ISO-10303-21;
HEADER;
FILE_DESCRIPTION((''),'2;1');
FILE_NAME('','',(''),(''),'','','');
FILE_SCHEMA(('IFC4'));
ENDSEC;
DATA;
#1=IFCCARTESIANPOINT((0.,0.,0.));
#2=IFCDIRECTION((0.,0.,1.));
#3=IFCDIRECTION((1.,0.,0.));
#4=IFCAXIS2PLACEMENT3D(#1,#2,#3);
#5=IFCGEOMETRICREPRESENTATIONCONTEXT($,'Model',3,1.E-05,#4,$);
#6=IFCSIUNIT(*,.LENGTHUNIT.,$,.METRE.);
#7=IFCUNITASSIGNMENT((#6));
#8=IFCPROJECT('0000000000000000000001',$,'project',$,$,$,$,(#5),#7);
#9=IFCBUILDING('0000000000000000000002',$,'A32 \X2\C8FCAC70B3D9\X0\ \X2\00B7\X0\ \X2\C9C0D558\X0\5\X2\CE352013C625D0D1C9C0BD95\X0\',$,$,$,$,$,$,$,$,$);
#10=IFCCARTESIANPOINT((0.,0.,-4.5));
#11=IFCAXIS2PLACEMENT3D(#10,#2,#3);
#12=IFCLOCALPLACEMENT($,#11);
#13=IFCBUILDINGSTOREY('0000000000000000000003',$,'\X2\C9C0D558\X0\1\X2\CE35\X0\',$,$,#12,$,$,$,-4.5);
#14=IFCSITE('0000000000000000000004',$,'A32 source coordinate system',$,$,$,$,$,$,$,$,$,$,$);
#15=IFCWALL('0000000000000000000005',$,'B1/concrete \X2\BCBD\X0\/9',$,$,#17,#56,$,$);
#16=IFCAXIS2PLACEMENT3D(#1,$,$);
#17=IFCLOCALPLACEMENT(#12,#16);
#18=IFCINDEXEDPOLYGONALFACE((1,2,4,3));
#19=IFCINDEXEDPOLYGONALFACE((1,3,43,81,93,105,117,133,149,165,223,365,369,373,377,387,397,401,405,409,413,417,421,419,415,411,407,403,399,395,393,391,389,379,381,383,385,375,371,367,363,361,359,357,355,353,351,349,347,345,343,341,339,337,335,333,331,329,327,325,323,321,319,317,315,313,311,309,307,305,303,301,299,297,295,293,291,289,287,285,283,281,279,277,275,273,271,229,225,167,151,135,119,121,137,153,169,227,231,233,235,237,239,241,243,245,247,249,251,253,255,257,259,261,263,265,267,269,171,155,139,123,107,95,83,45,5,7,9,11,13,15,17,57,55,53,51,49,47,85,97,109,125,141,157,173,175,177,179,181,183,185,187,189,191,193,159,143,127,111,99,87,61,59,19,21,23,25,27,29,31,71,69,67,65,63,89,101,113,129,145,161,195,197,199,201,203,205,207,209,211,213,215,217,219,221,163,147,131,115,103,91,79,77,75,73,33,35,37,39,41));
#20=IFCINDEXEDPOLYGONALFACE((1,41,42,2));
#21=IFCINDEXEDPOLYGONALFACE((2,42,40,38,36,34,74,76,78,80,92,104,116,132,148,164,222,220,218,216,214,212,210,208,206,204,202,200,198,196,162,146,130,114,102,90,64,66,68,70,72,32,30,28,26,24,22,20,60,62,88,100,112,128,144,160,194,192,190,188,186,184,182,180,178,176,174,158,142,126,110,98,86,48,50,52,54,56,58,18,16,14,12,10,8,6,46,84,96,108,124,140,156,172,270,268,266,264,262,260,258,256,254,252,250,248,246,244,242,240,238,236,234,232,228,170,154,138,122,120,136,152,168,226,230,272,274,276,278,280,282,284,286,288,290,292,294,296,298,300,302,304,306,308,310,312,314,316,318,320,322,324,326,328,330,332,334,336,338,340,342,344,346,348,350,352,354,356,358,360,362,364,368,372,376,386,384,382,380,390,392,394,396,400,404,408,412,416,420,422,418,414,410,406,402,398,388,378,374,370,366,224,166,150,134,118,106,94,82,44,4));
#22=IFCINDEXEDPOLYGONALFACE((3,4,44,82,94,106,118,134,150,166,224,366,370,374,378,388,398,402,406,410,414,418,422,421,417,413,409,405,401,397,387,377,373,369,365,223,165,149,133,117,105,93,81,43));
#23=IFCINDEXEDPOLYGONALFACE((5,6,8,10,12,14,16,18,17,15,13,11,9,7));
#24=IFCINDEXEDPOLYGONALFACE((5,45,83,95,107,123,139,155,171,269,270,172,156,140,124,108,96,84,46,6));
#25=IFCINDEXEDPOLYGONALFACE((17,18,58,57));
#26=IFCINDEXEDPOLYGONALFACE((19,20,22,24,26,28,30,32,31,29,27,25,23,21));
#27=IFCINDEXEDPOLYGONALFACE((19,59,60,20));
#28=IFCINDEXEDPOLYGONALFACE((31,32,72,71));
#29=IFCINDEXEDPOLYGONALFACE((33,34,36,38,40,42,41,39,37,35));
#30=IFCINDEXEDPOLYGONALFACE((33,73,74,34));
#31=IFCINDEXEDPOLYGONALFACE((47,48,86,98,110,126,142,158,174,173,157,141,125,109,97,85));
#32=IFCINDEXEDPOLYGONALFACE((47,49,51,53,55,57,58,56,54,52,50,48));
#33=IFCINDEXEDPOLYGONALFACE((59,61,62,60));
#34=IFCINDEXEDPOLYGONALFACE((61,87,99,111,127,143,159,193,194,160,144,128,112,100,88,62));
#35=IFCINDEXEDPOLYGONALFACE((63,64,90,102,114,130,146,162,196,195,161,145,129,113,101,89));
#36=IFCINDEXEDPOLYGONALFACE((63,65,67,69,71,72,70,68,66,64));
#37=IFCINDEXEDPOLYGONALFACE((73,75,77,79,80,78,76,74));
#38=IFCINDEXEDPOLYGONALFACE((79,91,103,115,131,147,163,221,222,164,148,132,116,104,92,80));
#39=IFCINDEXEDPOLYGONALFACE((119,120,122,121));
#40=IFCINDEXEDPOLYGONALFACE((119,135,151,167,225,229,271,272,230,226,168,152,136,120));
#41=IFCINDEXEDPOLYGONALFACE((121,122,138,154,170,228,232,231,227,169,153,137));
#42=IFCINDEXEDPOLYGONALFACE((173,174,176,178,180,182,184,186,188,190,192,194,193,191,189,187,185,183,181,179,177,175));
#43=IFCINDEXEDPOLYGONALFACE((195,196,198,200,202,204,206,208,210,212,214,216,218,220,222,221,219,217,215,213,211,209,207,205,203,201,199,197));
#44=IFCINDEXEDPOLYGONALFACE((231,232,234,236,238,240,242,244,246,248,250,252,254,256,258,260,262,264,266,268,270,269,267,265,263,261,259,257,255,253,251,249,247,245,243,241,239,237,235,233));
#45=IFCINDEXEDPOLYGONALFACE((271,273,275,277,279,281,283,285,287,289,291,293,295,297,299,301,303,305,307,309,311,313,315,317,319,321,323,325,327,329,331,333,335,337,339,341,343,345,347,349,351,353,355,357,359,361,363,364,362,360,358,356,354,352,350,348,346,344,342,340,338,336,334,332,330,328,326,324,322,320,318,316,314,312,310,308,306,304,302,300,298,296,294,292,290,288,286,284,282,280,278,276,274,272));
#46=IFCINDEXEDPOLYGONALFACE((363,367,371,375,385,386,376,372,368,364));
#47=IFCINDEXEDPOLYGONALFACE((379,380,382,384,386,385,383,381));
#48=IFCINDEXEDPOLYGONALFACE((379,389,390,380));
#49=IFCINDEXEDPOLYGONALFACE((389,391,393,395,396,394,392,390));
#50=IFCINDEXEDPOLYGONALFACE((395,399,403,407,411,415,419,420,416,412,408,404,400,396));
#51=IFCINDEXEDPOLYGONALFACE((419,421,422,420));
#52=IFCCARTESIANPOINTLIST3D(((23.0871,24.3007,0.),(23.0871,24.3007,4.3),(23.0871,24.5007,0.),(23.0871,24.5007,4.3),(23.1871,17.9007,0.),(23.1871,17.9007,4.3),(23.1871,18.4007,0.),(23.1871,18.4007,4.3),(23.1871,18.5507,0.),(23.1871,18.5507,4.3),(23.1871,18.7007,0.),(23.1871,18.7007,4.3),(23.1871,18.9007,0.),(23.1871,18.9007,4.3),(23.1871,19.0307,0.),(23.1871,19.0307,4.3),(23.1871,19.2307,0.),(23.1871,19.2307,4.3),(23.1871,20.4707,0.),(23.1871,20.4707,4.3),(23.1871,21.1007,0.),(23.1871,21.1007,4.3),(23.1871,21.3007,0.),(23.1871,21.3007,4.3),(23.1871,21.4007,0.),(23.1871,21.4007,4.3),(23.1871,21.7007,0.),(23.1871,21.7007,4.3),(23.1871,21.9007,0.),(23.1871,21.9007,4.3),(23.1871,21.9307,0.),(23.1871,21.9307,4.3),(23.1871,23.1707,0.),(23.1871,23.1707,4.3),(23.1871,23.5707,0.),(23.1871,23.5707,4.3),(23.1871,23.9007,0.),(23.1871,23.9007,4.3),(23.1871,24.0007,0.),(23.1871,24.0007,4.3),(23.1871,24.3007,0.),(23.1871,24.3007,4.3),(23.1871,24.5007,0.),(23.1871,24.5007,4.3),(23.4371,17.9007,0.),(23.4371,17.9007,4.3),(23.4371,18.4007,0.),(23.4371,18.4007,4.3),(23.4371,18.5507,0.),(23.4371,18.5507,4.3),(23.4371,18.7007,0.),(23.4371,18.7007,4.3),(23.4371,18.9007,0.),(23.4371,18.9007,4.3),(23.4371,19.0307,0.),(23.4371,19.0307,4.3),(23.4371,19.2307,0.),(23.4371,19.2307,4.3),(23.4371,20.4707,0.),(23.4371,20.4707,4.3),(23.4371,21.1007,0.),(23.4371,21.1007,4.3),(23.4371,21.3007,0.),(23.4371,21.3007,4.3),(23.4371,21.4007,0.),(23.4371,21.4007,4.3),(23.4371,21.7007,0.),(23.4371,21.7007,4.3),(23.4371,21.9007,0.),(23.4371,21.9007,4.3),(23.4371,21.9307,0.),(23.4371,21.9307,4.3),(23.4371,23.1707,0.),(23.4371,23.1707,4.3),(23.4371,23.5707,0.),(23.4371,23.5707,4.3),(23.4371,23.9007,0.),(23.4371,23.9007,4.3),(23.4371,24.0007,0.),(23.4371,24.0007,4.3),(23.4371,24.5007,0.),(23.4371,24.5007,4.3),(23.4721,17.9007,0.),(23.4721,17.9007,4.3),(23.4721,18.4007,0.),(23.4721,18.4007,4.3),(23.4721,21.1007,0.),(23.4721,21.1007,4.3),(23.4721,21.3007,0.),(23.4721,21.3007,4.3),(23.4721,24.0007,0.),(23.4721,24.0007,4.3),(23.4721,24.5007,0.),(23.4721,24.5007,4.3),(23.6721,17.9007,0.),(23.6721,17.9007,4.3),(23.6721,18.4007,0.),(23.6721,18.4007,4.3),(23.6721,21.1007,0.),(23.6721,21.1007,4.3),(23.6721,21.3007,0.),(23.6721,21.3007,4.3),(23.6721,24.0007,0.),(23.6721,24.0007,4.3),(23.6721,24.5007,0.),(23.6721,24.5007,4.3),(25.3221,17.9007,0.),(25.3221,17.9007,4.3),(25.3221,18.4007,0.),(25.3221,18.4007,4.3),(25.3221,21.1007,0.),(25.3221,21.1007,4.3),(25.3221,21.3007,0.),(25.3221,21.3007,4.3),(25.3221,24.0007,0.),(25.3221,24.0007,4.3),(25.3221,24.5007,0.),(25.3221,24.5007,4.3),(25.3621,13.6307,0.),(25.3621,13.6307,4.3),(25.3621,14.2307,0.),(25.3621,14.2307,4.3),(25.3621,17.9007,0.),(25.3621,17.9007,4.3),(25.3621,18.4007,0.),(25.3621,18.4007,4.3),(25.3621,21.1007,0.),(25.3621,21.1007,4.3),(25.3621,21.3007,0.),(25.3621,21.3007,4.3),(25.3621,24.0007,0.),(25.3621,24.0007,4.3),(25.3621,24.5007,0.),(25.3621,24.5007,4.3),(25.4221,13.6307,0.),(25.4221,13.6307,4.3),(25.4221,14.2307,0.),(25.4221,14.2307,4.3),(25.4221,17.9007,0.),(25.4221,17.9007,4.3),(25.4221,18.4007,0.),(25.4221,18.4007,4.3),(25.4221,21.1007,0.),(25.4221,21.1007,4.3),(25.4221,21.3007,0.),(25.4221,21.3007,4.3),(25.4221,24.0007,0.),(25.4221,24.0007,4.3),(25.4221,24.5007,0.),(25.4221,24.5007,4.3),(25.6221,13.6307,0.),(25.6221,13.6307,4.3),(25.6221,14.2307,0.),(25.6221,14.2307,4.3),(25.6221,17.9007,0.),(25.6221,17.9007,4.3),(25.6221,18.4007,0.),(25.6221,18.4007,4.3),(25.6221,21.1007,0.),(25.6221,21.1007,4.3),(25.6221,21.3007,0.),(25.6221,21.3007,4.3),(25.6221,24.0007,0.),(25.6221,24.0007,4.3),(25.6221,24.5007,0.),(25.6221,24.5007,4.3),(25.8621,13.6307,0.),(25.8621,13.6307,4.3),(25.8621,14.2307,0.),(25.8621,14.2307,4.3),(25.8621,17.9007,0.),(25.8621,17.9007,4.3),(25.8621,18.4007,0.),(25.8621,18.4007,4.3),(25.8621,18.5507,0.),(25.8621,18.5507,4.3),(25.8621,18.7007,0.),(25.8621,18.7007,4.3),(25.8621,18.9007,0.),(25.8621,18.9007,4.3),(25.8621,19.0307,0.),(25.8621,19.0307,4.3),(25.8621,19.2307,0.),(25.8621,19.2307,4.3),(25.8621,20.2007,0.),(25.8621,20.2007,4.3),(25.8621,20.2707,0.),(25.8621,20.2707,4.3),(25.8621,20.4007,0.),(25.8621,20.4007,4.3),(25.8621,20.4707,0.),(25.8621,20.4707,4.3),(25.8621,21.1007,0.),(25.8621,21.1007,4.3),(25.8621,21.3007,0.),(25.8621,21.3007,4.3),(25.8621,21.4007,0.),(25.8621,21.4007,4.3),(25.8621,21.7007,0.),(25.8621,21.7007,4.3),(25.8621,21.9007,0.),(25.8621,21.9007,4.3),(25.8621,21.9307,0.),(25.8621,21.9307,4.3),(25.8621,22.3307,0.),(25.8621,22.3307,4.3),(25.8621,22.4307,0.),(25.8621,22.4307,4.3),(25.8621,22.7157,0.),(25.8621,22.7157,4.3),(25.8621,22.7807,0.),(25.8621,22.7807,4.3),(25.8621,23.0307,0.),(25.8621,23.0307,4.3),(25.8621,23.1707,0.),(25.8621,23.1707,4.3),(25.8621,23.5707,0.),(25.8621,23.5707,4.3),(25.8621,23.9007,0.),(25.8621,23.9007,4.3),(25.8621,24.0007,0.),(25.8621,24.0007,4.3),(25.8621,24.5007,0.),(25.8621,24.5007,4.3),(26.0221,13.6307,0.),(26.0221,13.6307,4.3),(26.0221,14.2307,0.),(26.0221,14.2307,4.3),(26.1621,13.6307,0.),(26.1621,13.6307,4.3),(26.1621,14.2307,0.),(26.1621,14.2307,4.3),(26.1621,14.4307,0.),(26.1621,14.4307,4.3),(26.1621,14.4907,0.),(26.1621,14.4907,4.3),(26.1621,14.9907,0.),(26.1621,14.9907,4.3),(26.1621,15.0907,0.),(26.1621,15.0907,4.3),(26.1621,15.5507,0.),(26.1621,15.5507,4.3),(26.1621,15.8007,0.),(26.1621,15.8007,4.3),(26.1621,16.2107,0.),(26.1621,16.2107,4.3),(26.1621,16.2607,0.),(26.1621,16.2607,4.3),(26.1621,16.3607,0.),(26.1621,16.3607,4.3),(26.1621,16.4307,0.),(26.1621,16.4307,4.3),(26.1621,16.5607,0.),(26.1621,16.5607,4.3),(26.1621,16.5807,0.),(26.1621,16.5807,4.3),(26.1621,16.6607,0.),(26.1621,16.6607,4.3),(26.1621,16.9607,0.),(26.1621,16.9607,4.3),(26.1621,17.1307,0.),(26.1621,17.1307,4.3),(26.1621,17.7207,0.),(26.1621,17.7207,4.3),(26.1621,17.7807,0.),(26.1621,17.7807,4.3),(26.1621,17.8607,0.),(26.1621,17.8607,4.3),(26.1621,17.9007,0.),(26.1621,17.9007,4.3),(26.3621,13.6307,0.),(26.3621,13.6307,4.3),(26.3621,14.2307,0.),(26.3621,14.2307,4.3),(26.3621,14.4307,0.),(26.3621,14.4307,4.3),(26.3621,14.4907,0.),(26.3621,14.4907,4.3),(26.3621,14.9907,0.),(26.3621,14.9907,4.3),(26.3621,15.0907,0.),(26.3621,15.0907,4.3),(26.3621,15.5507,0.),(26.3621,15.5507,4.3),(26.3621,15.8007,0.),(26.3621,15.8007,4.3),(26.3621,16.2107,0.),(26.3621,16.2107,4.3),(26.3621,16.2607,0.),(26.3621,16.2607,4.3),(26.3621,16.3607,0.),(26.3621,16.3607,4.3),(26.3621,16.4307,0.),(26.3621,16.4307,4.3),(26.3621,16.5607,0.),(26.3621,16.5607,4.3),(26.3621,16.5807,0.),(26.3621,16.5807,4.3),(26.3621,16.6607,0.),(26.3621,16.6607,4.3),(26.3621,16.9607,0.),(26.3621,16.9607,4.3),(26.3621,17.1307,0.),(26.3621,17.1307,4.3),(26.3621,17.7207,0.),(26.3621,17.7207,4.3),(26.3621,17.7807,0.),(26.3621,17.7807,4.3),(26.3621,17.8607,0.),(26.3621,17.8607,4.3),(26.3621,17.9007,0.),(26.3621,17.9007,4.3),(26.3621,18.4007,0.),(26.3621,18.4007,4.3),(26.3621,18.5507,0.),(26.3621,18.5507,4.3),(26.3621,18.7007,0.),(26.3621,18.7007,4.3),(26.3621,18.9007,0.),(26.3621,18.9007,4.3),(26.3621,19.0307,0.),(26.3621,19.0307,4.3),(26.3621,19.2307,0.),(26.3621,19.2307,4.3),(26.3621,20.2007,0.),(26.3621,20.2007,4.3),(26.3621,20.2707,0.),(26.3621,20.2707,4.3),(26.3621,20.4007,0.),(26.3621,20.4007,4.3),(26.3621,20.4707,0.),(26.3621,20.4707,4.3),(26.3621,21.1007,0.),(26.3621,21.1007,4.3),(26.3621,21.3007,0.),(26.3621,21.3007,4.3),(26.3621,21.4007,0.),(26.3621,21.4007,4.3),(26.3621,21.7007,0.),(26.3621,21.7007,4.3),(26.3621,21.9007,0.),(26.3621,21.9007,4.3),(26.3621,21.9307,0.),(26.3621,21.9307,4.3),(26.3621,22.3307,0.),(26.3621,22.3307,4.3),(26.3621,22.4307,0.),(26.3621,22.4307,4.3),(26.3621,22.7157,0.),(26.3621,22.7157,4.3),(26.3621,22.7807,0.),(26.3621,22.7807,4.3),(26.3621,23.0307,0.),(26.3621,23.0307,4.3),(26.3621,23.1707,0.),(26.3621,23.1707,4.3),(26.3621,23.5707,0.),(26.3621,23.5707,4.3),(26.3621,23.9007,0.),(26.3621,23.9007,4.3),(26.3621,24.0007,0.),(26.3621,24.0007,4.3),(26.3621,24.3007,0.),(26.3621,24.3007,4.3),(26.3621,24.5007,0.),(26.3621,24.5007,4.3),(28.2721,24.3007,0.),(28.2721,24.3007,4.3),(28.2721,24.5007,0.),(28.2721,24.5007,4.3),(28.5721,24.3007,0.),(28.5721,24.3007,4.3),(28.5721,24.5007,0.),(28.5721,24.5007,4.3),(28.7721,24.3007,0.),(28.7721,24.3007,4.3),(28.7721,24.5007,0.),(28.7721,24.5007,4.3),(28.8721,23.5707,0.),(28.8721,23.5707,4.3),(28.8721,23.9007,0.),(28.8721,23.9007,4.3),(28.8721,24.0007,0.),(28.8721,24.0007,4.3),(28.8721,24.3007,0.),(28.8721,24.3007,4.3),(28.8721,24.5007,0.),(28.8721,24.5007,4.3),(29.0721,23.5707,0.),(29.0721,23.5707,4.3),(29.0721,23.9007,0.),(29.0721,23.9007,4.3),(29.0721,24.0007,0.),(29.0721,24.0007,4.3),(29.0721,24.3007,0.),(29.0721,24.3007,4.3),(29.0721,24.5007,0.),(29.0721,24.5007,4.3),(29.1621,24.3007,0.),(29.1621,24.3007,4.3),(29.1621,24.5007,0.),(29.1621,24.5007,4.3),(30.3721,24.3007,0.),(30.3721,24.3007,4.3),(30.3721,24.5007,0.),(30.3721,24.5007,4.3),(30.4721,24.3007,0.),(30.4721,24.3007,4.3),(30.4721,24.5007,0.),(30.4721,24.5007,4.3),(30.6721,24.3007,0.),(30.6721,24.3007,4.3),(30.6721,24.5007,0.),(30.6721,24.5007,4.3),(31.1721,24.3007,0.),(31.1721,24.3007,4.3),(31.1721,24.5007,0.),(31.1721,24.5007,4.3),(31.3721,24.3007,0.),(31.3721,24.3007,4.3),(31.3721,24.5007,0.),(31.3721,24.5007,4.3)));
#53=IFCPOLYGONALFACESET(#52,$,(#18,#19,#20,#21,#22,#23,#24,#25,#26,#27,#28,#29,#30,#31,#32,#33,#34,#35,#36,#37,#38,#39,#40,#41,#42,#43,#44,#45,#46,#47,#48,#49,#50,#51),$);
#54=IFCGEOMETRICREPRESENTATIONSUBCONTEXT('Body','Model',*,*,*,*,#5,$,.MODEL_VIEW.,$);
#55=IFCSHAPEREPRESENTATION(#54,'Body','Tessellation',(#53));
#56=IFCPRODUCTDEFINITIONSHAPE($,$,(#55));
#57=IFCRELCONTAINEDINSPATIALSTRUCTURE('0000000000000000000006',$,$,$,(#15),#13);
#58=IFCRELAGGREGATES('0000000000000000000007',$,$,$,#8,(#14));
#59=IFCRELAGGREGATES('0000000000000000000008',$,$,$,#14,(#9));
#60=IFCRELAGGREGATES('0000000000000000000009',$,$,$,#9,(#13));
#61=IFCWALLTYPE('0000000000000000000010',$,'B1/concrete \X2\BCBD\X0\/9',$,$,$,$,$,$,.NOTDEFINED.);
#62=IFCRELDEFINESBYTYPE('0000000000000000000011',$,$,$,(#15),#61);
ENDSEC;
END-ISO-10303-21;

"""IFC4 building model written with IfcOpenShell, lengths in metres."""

from ifc_helpers import new_model, si_unit, frame, origin, origin_with_axes, place, context, subcontext, project, spatial, polyline, outline, extrude, source, transform, mapped, type_object, type_shapes, element, save


model = new_model("IFC4")

# Units and contexts
model_context = context("Model", 3, precision=1e-05, world=origin_with_axes())
body_context = subcontext(model_context, "Body", "Model", "MODEL_VIEW")
ifc_project = project(units=[si_unit("LENGTHUNIT", "METRE")], contexts=[model_context])

# Site, building, storey
site = spatial("IfcSite", under=ifc_project, Name="A32 source coordinate system")
building = spatial("IfcBuilding", under=site, Name="A32 주거동 · 지하5층–옥탑지붕")
storey_placement = place(None, frame((0.0, 0.0, -4.5), z_axis=(0.0, 0.0, 1.0), x_axis=(1.0, 0.0, 0.0)))
storey = spatial("IfcBuildingStorey", under=building, at=storey_placement, Name="지하1층", Elevation=-4.5)

# Wall
wall_type_1 = type_object("IfcWallType", Name="B1/concrete 벽/9", PredefinedType="NOTDEFINED")
shared_shape_1 = source(origin(), body_context, "Body", "SweptSolid", [
    extrude(outline(polyline([(23.4371, 18.7007), (23.4371, 18.5507), (23.4371, 18.4007), (23.4721, 18.4007), (23.6721, 18.4007), (25.3221, 18.4007), (25.3621, 18.4007), (25.4221, 18.4007), (25.6221, 18.4007), (25.8621, 18.4007), (25.8621, 18.5507), (25.8621, 18.7007), (25.8621, 18.9007), (25.8621, 19.0307), (25.8621, 19.2307), (25.8621, 20.2007), (25.8621, 20.2707), (25.8621, 20.4007), (25.8621, 20.4707), (25.8621, 21.1007), (25.6221, 21.1007), (25.4221, 21.1007), (25.3621, 21.1007), (25.3221, 21.1007), (23.6721, 21.1007), (23.4721, 21.1007), (23.4371, 21.1007), (23.4371, 20.4707), (23.1871, 20.4707), (23.1871, 21.1007), (23.1871, 21.3007), (23.1871, 21.4007), (23.1871, 21.7007), (23.1871, 21.9007), (23.1871, 21.9307), (23.4371, 21.9307), (23.4371, 21.9007), (23.4371, 21.7007), (23.4371, 21.4007), (23.4371, 21.3007), (23.4721, 21.3007), (23.6721, 21.3007), (25.3221, 21.3007), (25.3621, 21.3007), (25.4221, 21.3007), (25.6221, 21.3007), (25.8621, 21.3007), (25.8621, 21.4007), (25.8621, 21.7007), (25.8621, 21.9007), (25.8621, 21.9307), (25.8621, 22.3307), (25.8621, 22.4307), (25.8621, 22.7157), (25.8621, 22.7807), (25.8621, 23.0307), (25.8621, 23.1707), (25.8621, 23.5707), (25.8621, 23.9007), (25.8621, 24.0007), (25.6221, 24.0007), (25.4221, 24.0007), (25.3621, 24.0007), (25.3221, 24.0007), (23.6721, 24.0007), (23.4721, 24.0007), (23.4371, 24.0007), (23.4371, 23.9007), (23.4371, 23.5707), (23.4371, 23.1707), (23.1871, 23.1707), (23.1871, 23.5707), (23.1871, 23.9007), (23.1871, 24.0007), (23.1871, 24.3007), (23.0871, 24.3007), (23.0871, 24.5007), (23.1871, 24.5007), (23.4371, 24.5007), (23.4721, 24.5007), (23.6721, 24.5007), (25.3221, 24.5007), (25.3621, 24.5007), (25.4221, 24.5007), (25.6221, 24.5007), (25.8621, 24.5007), (26.3621, 24.5007), (28.2721, 24.5007), (28.5721, 24.5007), (28.7721, 24.5007), (28.8721, 24.5007), (29.0721, 24.5007), (29.1621, 24.5007), (30.3721, 24.5007), (30.4721, 24.5007), (30.6721, 24.5007), (31.1721, 24.5007), (31.3721, 24.5007), (31.3721, 24.3007), (31.1721, 24.3007), (30.6721, 24.3007), (30.4721, 24.3007), (30.3721, 24.3007), (29.1621, 24.3007), (29.0721, 24.3007), (29.0721, 24.0007), (29.0721, 23.9007), (29.0721, 23.5707), (28.8721, 23.5707), (28.8721, 23.9007), (28.8721, 24.0007), (28.8721, 24.3007), (28.7721, 24.3007), (28.5721, 24.3007), (28.2721, 24.3007), (26.3621, 24.3007), (26.3621, 24.0007), (26.3621, 23.9007), (26.3621, 23.5707), (26.3621, 23.1707), (26.3621, 23.0307), (26.3621, 22.7807), (26.3621, 22.7157), (26.3621, 22.4307), (26.3621, 22.3307), (26.3621, 21.9307), (26.3621, 21.9007), (26.3621, 21.7007), (26.3621, 21.4007), (26.3621, 21.3007), (26.3621, 21.1007), (26.3621, 20.4707), (26.3621, 20.4007), (26.3621, 20.2707), (26.3621, 20.2007), (26.3621, 19.2307), (26.3621, 19.0307), (26.3621, 18.9007), (26.3621, 18.7007), (26.3621, 18.5507), (26.3621, 18.4007), (26.3621, 17.9007), (26.3621, 17.8607), (26.3621, 17.7807), (26.3621, 17.7207), (26.3621, 17.1307), (26.3621, 16.9607), (26.3621, 16.6607), (26.3621, 16.5807), (26.3621, 16.5607), (26.3621, 16.4307), (26.3621, 16.3607), (26.3621, 16.2607), (26.3621, 16.2107), (26.3621, 15.8007), (26.3621, 15.5507), (26.3621, 15.0907), (26.3621, 14.9907), (26.3621, 14.4907), (26.3621, 14.4307), (26.3621, 14.2307), (26.3621, 13.6307), (26.1621, 13.6307), (26.0221, 13.6307), (25.8621, 13.6307), (25.6221, 13.6307), (25.4221, 13.6307), (25.3621, 13.6307), (25.3621, 14.2307), (25.4221, 14.2307), (25.6221, 14.2307), (25.8621, 14.2307), (26.0221, 14.2307), (26.1621, 14.2307), (26.1621, 14.4307), (26.1621, 14.4907), (26.1621, 14.9907), (26.1621, 15.0907), (26.1621, 15.5507), (26.1621, 15.8007), (26.1621, 16.2107), (26.1621, 16.2607), (26.1621, 16.3607), (26.1621, 16.4307), (26.1621, 16.5607), (26.1621, 16.5807), (26.1621, 16.6607), (26.1621, 16.9607), (26.1621, 17.1307), (26.1621, 17.7207), (26.1621, 17.7807), (26.1621, 17.8607), (26.1621, 17.9007), (25.8621, 17.9007), (25.6221, 17.9007), (25.4221, 17.9007), (25.3621, 17.9007), (25.3221, 17.9007), (23.6721, 17.9007), (23.4721, 17.9007), (23.4371, 17.9007), (23.1871, 17.9007), (23.1871, 18.4007), (23.1871, 18.5507), (23.1871, 18.7007), (23.1871, 18.9007), (23.1871, 19.0307), (23.1871, 19.2307), (23.4371, 19.2307), (23.4371, 19.0307), (23.4371, 18.9007), (23.4371, 18.7007)])), origin(), (0.0, 0.0, 1.0), 4.3),
])
type_shapes(wall_type_1, [shared_shape_1])
wall_1_placement = place(storey_placement, origin_with_axes())
element("IfcWall", 1, at=wall_1_placement, inside=storey, type_object=wall_type_1, Name="B1/concrete 벽/9", context=body_context, shape_type="MappedRepresentation", body=[
    mapped(shared_shape_1, transform((0.0, 0.0, 0.0), scale=1.0)),
])

save(model, "model.ifc")
